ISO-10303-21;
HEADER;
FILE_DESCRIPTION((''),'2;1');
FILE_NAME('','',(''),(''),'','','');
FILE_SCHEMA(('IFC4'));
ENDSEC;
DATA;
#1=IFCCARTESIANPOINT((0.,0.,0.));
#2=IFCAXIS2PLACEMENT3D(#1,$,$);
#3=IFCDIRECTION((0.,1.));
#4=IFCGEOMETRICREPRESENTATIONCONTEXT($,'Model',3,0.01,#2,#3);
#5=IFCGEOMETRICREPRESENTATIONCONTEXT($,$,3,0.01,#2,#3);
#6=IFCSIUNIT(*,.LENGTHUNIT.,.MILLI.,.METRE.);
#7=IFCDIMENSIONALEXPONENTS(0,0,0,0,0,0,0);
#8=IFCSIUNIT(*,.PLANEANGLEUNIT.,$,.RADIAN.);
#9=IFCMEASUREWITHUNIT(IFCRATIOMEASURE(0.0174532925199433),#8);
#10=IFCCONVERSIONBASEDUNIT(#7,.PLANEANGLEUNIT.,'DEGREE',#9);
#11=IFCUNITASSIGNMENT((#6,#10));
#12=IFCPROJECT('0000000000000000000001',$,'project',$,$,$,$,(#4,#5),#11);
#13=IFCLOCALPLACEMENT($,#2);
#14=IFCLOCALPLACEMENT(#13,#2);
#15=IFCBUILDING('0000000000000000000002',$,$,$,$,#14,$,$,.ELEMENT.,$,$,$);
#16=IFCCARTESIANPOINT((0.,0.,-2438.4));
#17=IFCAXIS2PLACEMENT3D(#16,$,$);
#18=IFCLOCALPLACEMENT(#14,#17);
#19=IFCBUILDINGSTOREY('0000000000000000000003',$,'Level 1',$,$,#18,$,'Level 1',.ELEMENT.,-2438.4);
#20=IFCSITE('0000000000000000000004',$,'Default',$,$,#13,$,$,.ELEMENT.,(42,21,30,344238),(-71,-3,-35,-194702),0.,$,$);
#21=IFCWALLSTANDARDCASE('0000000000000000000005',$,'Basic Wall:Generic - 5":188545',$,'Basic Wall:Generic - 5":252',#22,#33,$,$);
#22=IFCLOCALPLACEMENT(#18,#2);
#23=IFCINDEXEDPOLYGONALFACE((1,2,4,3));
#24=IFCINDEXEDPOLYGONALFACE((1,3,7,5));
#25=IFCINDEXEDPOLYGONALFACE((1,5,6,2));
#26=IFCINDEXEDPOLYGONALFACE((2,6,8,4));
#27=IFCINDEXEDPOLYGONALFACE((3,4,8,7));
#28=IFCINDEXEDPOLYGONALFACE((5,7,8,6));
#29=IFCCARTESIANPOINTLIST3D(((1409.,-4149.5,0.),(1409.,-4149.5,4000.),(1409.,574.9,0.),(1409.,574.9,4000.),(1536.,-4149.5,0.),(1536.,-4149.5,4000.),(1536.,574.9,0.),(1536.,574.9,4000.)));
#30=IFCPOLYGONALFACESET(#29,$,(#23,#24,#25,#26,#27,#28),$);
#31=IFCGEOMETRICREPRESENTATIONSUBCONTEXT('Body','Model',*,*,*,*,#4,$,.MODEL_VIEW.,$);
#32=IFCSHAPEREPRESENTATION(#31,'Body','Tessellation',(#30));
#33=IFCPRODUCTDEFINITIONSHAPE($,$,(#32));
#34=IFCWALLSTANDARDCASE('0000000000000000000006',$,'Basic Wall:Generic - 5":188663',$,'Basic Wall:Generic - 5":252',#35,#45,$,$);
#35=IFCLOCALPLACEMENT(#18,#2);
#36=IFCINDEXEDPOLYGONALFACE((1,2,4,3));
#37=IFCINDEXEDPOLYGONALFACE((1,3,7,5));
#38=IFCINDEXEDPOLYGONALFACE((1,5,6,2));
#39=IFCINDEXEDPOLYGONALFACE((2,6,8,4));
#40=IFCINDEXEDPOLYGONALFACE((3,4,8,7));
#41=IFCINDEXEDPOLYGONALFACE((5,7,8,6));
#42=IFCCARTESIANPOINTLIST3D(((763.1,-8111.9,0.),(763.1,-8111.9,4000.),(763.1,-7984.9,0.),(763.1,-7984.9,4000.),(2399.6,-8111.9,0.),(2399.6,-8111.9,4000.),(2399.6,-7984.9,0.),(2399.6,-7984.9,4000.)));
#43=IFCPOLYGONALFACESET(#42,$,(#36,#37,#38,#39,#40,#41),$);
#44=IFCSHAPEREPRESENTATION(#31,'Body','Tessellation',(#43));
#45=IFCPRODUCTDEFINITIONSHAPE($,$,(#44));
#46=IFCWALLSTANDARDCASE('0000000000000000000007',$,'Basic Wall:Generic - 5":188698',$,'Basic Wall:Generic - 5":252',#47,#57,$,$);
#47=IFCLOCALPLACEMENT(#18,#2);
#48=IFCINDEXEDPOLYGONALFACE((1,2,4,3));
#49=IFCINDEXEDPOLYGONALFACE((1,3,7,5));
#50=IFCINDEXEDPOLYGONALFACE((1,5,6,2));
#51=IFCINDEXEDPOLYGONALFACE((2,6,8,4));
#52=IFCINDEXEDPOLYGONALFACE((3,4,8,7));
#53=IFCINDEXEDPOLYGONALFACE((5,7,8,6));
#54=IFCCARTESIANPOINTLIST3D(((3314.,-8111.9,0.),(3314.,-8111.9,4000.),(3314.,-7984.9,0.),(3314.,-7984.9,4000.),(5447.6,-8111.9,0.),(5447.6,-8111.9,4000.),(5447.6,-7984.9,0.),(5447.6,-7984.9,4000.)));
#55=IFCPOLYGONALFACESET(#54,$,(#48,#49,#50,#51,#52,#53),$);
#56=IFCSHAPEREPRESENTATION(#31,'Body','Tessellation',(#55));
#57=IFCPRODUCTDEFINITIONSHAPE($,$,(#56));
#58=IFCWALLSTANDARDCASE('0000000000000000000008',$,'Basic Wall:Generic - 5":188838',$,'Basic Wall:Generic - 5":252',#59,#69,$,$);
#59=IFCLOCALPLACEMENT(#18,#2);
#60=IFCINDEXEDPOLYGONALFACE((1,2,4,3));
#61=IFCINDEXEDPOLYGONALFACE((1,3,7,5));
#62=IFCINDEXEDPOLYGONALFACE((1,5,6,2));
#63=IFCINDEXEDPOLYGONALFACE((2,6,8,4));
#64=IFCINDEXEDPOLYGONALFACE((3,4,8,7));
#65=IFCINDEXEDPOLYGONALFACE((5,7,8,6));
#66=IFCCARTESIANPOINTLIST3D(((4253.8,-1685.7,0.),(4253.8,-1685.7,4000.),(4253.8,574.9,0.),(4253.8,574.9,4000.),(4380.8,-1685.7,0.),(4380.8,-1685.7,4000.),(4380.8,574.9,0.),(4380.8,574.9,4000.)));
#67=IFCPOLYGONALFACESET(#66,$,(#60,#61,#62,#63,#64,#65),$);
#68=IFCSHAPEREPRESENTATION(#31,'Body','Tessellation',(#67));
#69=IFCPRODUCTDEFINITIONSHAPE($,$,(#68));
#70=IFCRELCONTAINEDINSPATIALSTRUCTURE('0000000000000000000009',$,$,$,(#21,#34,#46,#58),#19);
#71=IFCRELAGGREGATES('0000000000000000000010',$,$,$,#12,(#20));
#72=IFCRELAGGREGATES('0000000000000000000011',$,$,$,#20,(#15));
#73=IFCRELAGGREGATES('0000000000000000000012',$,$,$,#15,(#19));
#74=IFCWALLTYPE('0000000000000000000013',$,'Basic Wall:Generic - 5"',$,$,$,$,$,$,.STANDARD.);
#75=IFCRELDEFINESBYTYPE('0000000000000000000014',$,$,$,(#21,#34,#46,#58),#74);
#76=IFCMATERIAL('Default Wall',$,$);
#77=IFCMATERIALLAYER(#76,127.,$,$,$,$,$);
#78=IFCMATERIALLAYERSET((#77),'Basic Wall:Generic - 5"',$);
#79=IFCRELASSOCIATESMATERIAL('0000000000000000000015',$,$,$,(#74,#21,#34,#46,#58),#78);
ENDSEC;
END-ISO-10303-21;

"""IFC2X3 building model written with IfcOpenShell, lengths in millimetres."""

from ifc_helpers import new_model, entity, si_unit, converted_unit, direction, frame, frame_2d, origin, place, context, subcontext, project, spatial, polyline, rectangle, extrude, clip, bounded_halfspace, material, layer, layer_set, layer_usage, type_object, element, save


model = new_model("IFC2X3")

# Units and contexts
model_context = context("Model", 3, precision=0.01, world=origin(), true_north=direction((0.0, 1.0)))
context_of_model = context(None, 3, precision=0.01, world=origin(), true_north=direction((0.0, 1.0)))
body_context = subcontext(model_context, "Body", "Model", "MODEL_VIEW")
ifc_project = project(units=[si_unit("LENGTHUNIT", "METRE", prefix="MILLI"), converted_unit("PLANEANGLEUNIT", "DEGREE", entity("IfcRatioMeasure", 0.0174532925199433), si_unit("PLANEANGLEUNIT", "RADIAN"), dimensions=[0, 0, 0, 0, 0, 0, 0])], contexts=[model_context, context_of_model])

# Site, building, storey
site_placement = place(None, origin())
site = spatial("IfcSite", under=ifc_project, at=site_placement, Name="Default", CompositionType="ELEMENT", RefLatitude=(42, 21, 30, 344238), RefLongitude=(-71, -3, -35, -194702), RefElevation=0.0)
building_placement = place(site_placement, origin())
building = spatial("IfcBuilding", under=site, at=building_placement, CompositionType="ELEMENT")
storey_placement = place(building_placement, frame((0.0, 0.0, -2438.4)))
storey = spatial("IfcBuildingStorey", under=building, at=storey_placement, Name="Level 1", LongName="Level 1", CompositionType="ELEMENT", Elevation=-2438.4)

# Shared definitions
ifc_material = material(Name="Default Wall")
ifc_layer = layer(ifc_material, 127.0)
ifc_layer_set = layer_set([ifc_layer], Name="Basic Wall:Generic - 5\"")
wall_type = type_object("IfcWallType", Name="Basic Wall:Generic - 5\"", PredefinedType="STANDARD", material=ifc_layer_set)

# Walls
ifc_layer_usage_1 = layer_usage(ifc_layer_set, "AXIS2", "NEGATIVE", 63.5)
wall_1_placement = place(storey_placement, frame((1472.5, -4149.5, 0.0), z_axis=(0.0, 0.0, 1.0), x_axis=(0.0, 1.0, 0.0)))
element("IfcWallStandardCase", 1, at=wall_1_placement, inside=storey, type_object=wall_type, material=ifc_layer_usage_1, Name="Basic Wall:Generic - 5\":188545", ObjectType="Basic Wall:Generic - 5\":252", context=body_context, shape_type="Clipping", body=[
    clip(extrude(rectangle(XDim=4724.4, YDim=127.0, at=frame_2d((2362.2, 0.0), x_axis=(-1.0, 0.0))), origin(), (0.0, 0.0, 1.0), 4000.0), bounded_halfspace(frame((0.0, -63.5, 4000.0), z_axis=(0.0, 0.0, -1.0), x_axis=(-1.0, 0.0, 0.0)), True, frame((0.0, -63.5, 4000.0)), polyline([(0.0, 0.0), (2514.6, 0.0), (2641.6, 0.0), (4724.4, 0.0), (4724.4, 127.0), (0.0, 127.0), (0.0, 0.0)]))),
])
ifc_layer_usage_2 = layer_usage(ifc_layer_set, "AXIS2", "NEGATIVE", 63.5)
wall_2_placement = place(storey_placement, frame((2399.6, -8048.4, 0.0), z_axis=(0.0, 0.0, 1.0), x_axis=(-1.0, 0.0, 0.0)))
element("IfcWallStandardCase", 2, at=wall_2_placement, inside=storey, type_object=wall_type, material=ifc_layer_usage_2, Name="Basic Wall:Generic - 5\":188663", ObjectType="Basic Wall:Generic - 5\":252", context=body_context, shape_type="Clipping", body=[
    clip(extrude(rectangle(XDim=1636.5, YDim=127.0, at=frame_2d((818.2, 0.0), x_axis=(-1.0, 0.0))), origin(), (0.0, 0.0, 1.0), 4000.0), bounded_halfspace(frame((0.0, -63.5, 4000.0), z_axis=(0.0, 0.0, -1.0), x_axis=(0.0, 1.0, 0.0)), True, frame((0.0, -63.5, 4000.0)), polyline([(0.0, 0.0), (1636.5, 0.0), (1636.5, 127.0), (0.0, 127.0), (0.0, 0.0)]))),
])
ifc_layer_usage_3 = layer_usage(ifc_layer_set, "AXIS2", "POSITIVE", -63.5)
wall_3_placement = place(storey_placement, frame((3314.0, -8048.4, 0.0)))
element("IfcWallStandardCase", 3, at=wall_3_placement, inside=storey, type_object=wall_type, material=ifc_layer_usage_3, Name="Basic Wall:Generic - 5\":188698", ObjectType="Basic Wall:Generic - 5\":252", context=body_context, shape_type="Clipping", body=[
    clip(extrude(rectangle(XDim=2133.6, YDim=127.0, at=frame_2d((1066.8, 0.0), x_axis=(-1.0, 0.0))), origin(), (0.0, 0.0, 1.0), 4000.0), bounded_halfspace(frame((0.0, -63.5, 4000.0), z_axis=(0.0, 0.0, -1.0), x_axis=(0.0, -1.0, 0.0)), True, frame((0.0, -63.5, 4000.0)), polyline([(0.0, 0.0), (2133.6, 0.0), (2133.6, 127.0), (0.0, 127.0), (0.0, 0.0)]))),
])
ifc_layer_usage_4 = layer_usage(ifc_layer_set, "AXIS2", "POSITIVE", -63.5)
wall_4_placement = place(storey_placement, frame((4317.3, -1685.7, 0.0), z_axis=(0.0, 0.0, 1.0), x_axis=(0.0, 1.0, 0.0)))
element("IfcWallStandardCase", 4, at=wall_4_placement, inside=storey, type_object=wall_type, material=ifc_layer_usage_4, Name="Basic Wall:Generic - 5\":188838", ObjectType="Basic Wall:Generic - 5\":252", context=body_context, shape_type="Clipping", body=[
    clip(extrude(rectangle(XDim=2260.6, YDim=127.0, at=frame_2d((1130.3, 0.0), x_axis=(-1.0, 0.0))), origin(), (0.0, 0.0, 1.0), 4000.0), bounded_halfspace(frame((0.0, -63.5, 4000.0), z_axis=(0.0, 0.0, -1.0), x_axis=(-1.0, 0.0, 0.0)), True, frame((0.0, -63.5, 4000.0)), polyline([(0.0, 0.0), (2260.6, 0.0), (2260.6, 127.0), (177.8, 127.0), (50.8, 127.0), (0.0, 127.0), (0.0, 0.0)]))),
])

save(model, "model.ifc")
